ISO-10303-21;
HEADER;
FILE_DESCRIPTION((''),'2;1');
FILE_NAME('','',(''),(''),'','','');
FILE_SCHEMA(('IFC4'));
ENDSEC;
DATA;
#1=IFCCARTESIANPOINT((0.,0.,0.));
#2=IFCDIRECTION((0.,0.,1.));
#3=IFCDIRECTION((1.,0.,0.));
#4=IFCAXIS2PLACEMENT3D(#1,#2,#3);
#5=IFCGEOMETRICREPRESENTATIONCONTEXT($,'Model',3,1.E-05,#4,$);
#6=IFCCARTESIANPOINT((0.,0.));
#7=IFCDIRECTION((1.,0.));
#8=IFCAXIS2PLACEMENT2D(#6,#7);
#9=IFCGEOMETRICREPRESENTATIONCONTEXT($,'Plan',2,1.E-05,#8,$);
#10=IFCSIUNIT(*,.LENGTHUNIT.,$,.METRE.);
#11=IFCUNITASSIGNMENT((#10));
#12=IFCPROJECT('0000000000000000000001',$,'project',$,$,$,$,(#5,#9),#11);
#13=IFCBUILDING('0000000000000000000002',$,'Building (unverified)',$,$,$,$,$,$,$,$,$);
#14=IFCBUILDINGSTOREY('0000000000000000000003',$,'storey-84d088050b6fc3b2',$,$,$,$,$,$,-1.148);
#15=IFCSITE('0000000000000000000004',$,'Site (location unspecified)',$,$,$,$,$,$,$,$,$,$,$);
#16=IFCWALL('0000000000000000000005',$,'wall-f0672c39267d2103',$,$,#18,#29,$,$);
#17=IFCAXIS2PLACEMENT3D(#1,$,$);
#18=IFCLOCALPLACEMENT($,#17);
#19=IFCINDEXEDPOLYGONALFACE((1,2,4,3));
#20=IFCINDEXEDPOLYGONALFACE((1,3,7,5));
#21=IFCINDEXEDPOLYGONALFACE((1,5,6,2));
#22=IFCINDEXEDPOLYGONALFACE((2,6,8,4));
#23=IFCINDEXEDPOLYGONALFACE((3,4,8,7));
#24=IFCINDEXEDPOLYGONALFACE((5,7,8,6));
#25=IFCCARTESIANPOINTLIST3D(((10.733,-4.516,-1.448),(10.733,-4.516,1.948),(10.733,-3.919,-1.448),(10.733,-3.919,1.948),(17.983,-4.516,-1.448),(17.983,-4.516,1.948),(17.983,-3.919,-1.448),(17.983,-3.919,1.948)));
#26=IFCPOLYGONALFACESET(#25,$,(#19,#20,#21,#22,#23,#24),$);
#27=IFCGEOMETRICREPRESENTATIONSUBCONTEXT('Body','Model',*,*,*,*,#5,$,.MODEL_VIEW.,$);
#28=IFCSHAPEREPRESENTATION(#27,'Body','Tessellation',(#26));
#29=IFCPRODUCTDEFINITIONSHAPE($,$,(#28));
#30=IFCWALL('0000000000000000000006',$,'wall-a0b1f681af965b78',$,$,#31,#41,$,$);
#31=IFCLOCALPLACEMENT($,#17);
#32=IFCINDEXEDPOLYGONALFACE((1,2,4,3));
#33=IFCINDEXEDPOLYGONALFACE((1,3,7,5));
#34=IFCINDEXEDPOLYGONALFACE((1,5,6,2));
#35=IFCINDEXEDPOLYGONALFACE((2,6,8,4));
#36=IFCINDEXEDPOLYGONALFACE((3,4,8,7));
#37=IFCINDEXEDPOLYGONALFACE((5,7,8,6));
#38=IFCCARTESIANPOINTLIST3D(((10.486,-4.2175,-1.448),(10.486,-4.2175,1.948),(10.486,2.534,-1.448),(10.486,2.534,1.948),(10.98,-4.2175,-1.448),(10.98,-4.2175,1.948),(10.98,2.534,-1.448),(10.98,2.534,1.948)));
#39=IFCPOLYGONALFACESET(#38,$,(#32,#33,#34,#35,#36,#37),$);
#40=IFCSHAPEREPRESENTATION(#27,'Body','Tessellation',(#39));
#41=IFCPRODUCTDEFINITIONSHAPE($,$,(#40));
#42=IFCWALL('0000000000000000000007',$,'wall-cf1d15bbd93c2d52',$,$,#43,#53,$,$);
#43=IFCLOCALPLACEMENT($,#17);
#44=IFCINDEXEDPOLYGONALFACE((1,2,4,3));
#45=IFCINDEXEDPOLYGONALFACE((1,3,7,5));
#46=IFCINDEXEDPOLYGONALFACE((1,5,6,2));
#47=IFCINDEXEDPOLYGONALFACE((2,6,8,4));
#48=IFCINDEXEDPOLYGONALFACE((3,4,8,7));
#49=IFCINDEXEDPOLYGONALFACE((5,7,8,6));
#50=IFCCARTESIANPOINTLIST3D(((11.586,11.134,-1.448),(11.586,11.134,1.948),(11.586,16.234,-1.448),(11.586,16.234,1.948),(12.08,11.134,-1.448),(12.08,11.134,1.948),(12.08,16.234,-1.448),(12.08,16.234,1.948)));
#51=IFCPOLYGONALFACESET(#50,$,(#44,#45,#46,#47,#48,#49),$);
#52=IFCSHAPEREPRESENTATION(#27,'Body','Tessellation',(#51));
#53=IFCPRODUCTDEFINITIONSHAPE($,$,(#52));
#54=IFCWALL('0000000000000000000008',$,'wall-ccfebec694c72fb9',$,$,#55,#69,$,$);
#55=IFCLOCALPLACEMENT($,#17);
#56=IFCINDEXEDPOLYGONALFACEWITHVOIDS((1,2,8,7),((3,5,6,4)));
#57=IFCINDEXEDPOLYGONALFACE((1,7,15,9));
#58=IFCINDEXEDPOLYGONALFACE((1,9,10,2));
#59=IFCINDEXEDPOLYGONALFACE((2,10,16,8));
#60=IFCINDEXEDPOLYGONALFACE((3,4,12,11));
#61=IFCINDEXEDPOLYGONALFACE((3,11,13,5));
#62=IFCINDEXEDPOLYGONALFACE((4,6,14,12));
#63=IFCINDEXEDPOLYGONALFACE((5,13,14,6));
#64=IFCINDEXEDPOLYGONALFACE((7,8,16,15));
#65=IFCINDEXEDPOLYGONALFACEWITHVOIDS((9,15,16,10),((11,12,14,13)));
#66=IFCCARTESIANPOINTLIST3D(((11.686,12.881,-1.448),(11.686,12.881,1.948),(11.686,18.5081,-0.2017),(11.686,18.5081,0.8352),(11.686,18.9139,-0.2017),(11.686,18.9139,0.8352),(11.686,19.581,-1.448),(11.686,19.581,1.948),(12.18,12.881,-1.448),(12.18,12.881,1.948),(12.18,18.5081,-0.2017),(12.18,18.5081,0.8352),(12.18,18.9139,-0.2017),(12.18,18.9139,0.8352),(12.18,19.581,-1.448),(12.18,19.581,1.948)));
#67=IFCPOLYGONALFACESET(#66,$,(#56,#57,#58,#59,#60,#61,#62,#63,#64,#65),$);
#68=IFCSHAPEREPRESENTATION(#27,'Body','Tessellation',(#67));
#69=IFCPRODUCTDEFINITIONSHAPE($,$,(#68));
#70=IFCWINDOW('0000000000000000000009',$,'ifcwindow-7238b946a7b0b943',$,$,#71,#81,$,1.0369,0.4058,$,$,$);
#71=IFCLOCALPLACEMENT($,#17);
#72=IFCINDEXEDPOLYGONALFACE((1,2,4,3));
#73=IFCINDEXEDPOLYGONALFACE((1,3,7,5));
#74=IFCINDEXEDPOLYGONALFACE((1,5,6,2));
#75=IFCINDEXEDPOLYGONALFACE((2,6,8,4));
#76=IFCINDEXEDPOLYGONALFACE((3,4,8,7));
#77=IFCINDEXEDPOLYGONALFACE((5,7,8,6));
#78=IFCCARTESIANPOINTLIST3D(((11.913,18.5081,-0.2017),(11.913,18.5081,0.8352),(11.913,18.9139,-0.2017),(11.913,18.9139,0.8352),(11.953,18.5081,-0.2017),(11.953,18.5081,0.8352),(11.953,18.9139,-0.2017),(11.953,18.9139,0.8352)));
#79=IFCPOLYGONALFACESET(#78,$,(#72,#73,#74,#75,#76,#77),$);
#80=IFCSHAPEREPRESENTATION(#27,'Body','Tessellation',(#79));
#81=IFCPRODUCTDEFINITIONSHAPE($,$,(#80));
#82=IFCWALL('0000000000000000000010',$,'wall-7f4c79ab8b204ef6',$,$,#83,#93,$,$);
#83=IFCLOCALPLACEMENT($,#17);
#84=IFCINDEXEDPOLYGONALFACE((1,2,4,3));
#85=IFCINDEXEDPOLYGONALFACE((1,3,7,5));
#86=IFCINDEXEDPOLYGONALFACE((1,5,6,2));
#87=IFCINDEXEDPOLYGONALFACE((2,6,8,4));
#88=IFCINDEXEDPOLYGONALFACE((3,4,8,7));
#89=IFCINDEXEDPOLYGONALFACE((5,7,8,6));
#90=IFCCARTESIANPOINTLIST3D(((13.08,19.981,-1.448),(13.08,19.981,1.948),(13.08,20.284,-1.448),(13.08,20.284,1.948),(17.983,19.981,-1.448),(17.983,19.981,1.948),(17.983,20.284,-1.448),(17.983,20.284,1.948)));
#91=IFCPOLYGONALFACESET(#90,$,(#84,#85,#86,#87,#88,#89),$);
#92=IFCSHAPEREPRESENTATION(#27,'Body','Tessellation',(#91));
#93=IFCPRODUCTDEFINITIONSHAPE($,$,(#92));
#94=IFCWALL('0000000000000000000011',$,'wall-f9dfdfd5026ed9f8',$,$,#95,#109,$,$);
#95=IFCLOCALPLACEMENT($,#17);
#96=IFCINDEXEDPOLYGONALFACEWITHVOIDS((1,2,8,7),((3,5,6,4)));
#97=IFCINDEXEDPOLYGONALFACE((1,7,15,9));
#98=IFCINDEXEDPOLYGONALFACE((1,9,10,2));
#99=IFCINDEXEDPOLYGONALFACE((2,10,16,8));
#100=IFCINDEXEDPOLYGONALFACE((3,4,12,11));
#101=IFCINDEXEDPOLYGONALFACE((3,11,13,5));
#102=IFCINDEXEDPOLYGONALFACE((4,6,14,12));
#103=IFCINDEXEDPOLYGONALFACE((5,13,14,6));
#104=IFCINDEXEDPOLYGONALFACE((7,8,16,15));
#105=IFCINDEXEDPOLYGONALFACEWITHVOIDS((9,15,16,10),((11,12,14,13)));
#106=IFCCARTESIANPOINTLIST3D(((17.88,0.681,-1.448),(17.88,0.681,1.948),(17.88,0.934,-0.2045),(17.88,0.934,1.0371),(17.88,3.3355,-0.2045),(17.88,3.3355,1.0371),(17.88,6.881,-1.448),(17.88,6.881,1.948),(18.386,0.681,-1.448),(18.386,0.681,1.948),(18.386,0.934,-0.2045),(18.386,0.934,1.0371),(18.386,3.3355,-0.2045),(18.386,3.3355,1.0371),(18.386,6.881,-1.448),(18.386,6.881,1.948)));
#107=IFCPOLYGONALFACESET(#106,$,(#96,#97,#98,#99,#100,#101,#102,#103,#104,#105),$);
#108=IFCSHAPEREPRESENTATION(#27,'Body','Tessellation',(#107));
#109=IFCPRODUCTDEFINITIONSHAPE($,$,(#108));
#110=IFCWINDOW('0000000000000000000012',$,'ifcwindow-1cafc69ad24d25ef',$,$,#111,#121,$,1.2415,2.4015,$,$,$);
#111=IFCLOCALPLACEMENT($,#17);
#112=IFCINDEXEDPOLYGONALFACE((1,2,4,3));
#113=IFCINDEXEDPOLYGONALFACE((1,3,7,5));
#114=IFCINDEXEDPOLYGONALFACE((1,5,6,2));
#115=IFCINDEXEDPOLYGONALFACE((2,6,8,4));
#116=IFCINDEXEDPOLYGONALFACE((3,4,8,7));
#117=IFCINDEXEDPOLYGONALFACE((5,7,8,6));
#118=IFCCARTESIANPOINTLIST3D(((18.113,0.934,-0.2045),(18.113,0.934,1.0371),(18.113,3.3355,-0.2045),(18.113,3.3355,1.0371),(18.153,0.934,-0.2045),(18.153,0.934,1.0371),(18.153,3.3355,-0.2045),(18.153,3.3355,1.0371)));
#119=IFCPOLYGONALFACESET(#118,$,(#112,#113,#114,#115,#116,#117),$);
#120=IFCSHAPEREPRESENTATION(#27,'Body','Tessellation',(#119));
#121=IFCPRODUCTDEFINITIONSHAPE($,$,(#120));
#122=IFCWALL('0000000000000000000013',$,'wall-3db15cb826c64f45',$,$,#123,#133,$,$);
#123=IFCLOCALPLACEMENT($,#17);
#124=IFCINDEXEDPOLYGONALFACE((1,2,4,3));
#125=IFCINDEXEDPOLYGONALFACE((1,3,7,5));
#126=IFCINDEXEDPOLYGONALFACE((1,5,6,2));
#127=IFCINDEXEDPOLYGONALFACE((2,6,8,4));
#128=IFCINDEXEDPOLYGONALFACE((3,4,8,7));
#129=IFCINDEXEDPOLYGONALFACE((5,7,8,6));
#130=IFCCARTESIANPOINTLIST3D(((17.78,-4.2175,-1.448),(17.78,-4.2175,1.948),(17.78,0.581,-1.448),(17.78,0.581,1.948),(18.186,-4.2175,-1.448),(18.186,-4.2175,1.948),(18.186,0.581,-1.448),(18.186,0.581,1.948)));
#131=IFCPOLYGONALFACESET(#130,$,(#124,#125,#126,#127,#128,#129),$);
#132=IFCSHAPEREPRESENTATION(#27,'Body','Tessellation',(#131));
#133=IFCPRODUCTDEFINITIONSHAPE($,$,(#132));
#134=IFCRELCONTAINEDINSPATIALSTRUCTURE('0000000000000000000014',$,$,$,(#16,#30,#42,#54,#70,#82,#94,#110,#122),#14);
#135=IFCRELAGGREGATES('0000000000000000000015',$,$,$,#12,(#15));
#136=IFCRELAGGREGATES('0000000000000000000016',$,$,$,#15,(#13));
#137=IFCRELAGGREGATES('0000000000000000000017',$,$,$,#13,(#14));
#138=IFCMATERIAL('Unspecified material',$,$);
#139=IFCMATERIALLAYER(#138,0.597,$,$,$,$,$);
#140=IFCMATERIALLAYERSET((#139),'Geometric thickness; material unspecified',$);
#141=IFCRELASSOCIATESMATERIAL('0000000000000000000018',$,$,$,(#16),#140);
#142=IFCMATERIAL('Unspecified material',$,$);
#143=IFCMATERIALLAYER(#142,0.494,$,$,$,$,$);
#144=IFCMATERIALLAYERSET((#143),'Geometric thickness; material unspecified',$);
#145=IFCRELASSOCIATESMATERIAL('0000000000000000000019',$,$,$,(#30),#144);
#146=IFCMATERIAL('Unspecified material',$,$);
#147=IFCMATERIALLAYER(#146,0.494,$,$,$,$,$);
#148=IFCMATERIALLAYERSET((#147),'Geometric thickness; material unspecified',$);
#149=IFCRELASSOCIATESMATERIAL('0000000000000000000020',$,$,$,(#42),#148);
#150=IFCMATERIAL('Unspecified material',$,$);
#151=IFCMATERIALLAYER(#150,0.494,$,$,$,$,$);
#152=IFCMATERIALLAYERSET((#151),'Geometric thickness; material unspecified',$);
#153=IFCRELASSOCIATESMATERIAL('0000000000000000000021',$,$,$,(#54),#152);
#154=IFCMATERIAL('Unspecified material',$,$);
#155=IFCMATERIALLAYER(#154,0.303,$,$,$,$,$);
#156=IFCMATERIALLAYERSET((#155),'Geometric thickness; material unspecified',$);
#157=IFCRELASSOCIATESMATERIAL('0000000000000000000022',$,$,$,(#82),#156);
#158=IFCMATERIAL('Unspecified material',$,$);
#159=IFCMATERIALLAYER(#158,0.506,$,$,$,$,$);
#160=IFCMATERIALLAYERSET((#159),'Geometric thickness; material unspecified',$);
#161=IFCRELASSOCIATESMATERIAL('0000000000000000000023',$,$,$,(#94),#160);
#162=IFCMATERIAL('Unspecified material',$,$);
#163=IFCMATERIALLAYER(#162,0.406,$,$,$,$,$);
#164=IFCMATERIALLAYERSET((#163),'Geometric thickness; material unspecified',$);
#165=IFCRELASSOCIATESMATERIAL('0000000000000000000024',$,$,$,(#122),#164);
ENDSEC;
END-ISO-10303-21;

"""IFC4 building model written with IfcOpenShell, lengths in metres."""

from ifc_helpers import new_model, si_unit, frame, origin_with_axes, origin_2d_with_axis, place, context, subcontext, project, spatial, indexed_curve, outline, extrude, material, layer, layer_set, layer_usage, element, fill, save


model = new_model("IFC4")

# Units and contexts
model_context = context("Model", 3, precision=1e-05, world=origin_with_axes())
plan_context = context("Plan", 2, precision=1e-05, world=origin_2d_with_axis())
body_context = subcontext(model_context, "Body", "Model", "MODEL_VIEW")
ifc_project = project(units=[si_unit("LENGTHUNIT", "METRE")], contexts=[model_context, plan_context])

# Site, building, storey
site = spatial("IfcSite", under=ifc_project, Name="Site (location unspecified)")
building = spatial("IfcBuilding", under=site, Name="Building (unverified)")
storey = spatial("IfcBuildingStorey", under=building, Name="storey-84d088050b6fc3b2", Elevation=-1.148)

# Walls
ifc_material_1 = material(Name="Unspecified material")
ifc_layer_1 = layer(ifc_material_1, 0.597)
ifc_layer_set_1 = layer_set([ifc_layer_1], Name="Geometric thickness; material unspecified")
ifc_layer_usage_1 = layer_usage(ifc_layer_set_1, "AXIS2", "POSITIVE", -0.2985)
wall_1_placement = place(None, frame((17.983, -4.2175, -1.448), z_axis=(0.0, 0.0, 1.0), x_axis=(-1.0, 0.0, 0.0)))
element("IfcWall", 1, at=wall_1_placement, inside=storey, material=ifc_layer_usage_1, Name="wall-f0672c39267d2103", context=body_context, shape_type="SweptSolid", body=[
    extrude(outline(indexed_curve([(0.0, 0.0), (0.0, 0.597), (7.25, 0.597), (7.25, 0.0), (0.0, 0.0)], self_intersect=False)), frame((0.0, -0.2985, 0.0), z_axis=(0.0, 0.0, 1.0), x_axis=(1.0, 0.0, 0.0)), (0.0, 0.0, 1.0), 3.396),
])
ifc_material_2 = material(Name="Unspecified material")
ifc_layer_2 = layer(ifc_material_2, 0.494)
ifc_layer_set_2 = layer_set([ifc_layer_2], Name="Geometric thickness; material unspecified")
ifc_layer_usage_2 = layer_usage(ifc_layer_set_2, "AXIS2", "POSITIVE", -0.247)
wall_2_placement = place(None, frame((10.733, -4.2175, -1.448), z_axis=(0.0, 0.0, 1.0), x_axis=(0.0, 1.0, 0.0)))
element("IfcWall", 2, at=wall_2_placement, inside=storey, material=ifc_layer_usage_2, Name="wall-a0b1f681af965b78", context=body_context, shape_type="SweptSolid", body=[
    extrude(outline(indexed_curve([(0.0, 0.0), (0.0, 0.494), (6.7515, 0.494), (6.7515, 0.0), (0.0, 0.0)], self_intersect=False)), frame((0.0, -0.247, 0.0), z_axis=(0.0, 0.0, 1.0), x_axis=(1.0, 0.0, 0.0)), (0.0, 0.0, 1.0), 3.396),
])
ifc_material_3 = material(Name="Unspecified material")
ifc_layer_3 = layer(ifc_material_3, 0.494)
ifc_layer_set_3 = layer_set([ifc_layer_3], Name="Geometric thickness; material unspecified")
ifc_layer_usage_3 = layer_usage(ifc_layer_set_3, "AXIS2", "POSITIVE", -0.247)
wall_3_placement = place(None, frame((11.833, 11.134, -1.448), z_axis=(0.0, 0.0, 1.0), x_axis=(0.0, 1.0, 0.0)))
element("IfcWall", 3, at=wall_3_placement, inside=storey, material=ifc_layer_usage_3, Name="wall-cf1d15bbd93c2d52", context=body_context, shape_type="SweptSolid", body=[
    extrude(outline(indexed_curve([(0.0, 0.0), (0.0, 0.494), (5.1, 0.494), (5.1, 0.0), (0.0, 0.0)], self_intersect=False)), frame((0.0, -0.247, 0.0), z_axis=(0.0, 0.0, 1.0), x_axis=(1.0, 0.0, 0.0)), (0.0, 0.0, 1.0), 3.396),
])

# Wall, opening, window
ifc_material_4 = material(Name="Unspecified material")
ifc_layer_4 = layer(ifc_material_4, 0.494)
ifc_layer_set_4 = layer_set([ifc_layer_4], Name="Geometric thickness; material unspecified")
ifc_layer_usage_4 = layer_usage(ifc_layer_set_4, "AXIS2", "POSITIVE", -0.247)
wall_4_placement = place(None, frame((11.933, 12.881, -1.448), z_axis=(0.0, 0.0, 1.0), x_axis=(0.0, 1.0, 0.0)))
wall_4 = element("IfcWall", 4, at=wall_4_placement, inside=storey, material=ifc_layer_usage_4, Name="wall-ccfebec694c72fb9", context=body_context, shape_type="SweptSolid", body=[
    extrude(outline(indexed_curve([(0.0, 0.0), (0.0, 0.494), (6.7, 0.494), (6.7, 0.0), (0.0, 0.0)], self_intersect=False)), frame((0.0, -0.247, 0.0), z_axis=(0.0, 0.0, 1.0), x_axis=(1.0, 0.0, 0.0)), (0.0, 0.0, 1.0), 3.396),
])
opening_1_placement = place(wall_4_placement, frame((5.6271, -0.257, 1.2463), z_axis=(0.0, 0.0, 1.0), x_axis=(1.0, 0.0, 0.0)))
opening_1 = element("IfcOpeningElement", 5, at=opening_1_placement, cuts=wall_4, context=body_context, shape_type="SweptSolid", body=[
    extrude(outline(indexed_curve([(0.0, 0.0), (0.0, 0.514), (0.4058, 0.514), (0.4058, 0.0), (0.0, 0.0)], self_intersect=False)), origin_with_axes(), (0.0, 0.0, 1.0), 1.0369),
])
window_1_placement = place(None, frame((11.953, 18.5081, -0.2017), z_axis=(0.0, 0.0, 1.0), x_axis=(0.0, 1.0, 0.0)))
window_1 = element("IfcWindow", 6, at=window_1_placement, inside=storey, Name="ifcwindow-7238b946a7b0b943", OverallHeight=1.0369, OverallWidth=0.4058, context=body_context, shape_type="SweptSolid", body=[
    extrude(outline(indexed_curve([(0.0, 0.0), (0.0, 0.04), (0.4058, 0.04), (0.4058, 0.0), (0.0, 0.0)], self_intersect=False)), origin_with_axes(), (0.0, 0.0, 1.0), 1.0369),
])
fill(opening_1, window_1)

# Wall
ifc_material_5 = material(Name="Unspecified material")
ifc_layer_5 = layer(ifc_material_5, 0.303)
ifc_layer_set_5 = layer_set([ifc_layer_5], Name="Geometric thickness; material unspecified")
ifc_layer_usage_5 = layer_usage(ifc_layer_set_5, "AXIS2", "POSITIVE", -0.1515)
wall_5_placement = place(None, frame((13.08, 20.1325, -1.448), z_axis=(0.0, 0.0, 1.0), x_axis=(1.0, 0.0, 0.0)))
element("IfcWall", 7, at=wall_5_placement, inside=storey, material=ifc_layer_usage_5, Name="wall-7f4c79ab8b204ef6", context=body_context, shape_type="SweptSolid", body=[
    extrude(outline(indexed_curve([(0.0, 0.0), (0.0, 0.303), (4.903, 0.303), (4.903, 0.0), (0.0, 0.0)], self_intersect=False)), frame((0.0, -0.1515, 0.0), z_axis=(0.0, 0.0, 1.0), x_axis=(1.0, 0.0, 0.0)), (0.0, 0.0, 1.0), 3.396),
])

# Wall, opening, window
ifc_material_6 = material(Name="Unspecified material")
ifc_layer_6 = layer(ifc_material_6, 0.506)
ifc_layer_set_6 = layer_set([ifc_layer_6], Name="Geometric thickness; material unspecified")
ifc_layer_usage_6 = layer_usage(ifc_layer_set_6, "AXIS2", "POSITIVE", -0.253)
wall_6_placement = place(None, frame((18.133, 0.681, -1.448), z_axis=(0.0, 0.0, 1.0), x_axis=(0.0, 1.0, 0.0)))
wall_6 = element("IfcWall", 8, at=wall_6_placement, inside=storey, material=ifc_layer_usage_6, Name="wall-f9dfdfd5026ed9f8", context=body_context, shape_type="SweptSolid", body=[
    extrude(outline(indexed_curve([(0.0, 0.0), (0.0, 0.506), (6.2, 0.506), (6.2, 0.0), (0.0, 0.0)], self_intersect=False)), frame((0.0, -0.253, 0.0), z_axis=(0.0, 0.0, 1.0), x_axis=(1.0, 0.0, 0.0)), (0.0, 0.0, 1.0), 3.396),
])
opening_2_placement = place(wall_6_placement, frame((0.253, -0.263, 1.2435), z_axis=(0.0, 0.0, 1.0), x_axis=(1.0, 0.0, 0.0)))
opening_2 = element("IfcOpeningElement", 9, at=opening_2_placement, cuts=wall_6, context=body_context, shape_type="SweptSolid", body=[
    extrude(outline(indexed_curve([(0.0, 0.0), (0.0, 0.526), (2.4015, 0.526), (2.4015, 0.0), (0.0, 0.0)], self_intersect=False)), origin_with_axes(), (0.0, 0.0, 1.0), 1.2415),
])
window_2_placement = place(None, frame((18.153, 0.934, -0.2045), z_axis=(0.0, 0.0, 1.0), x_axis=(0.0, 1.0, 0.0)))
window_2 = element("IfcWindow", 10, at=window_2_placement, inside=storey, Name="ifcwindow-1cafc69ad24d25ef", OverallHeight=1.2415, OverallWidth=2.4015, context=body_context, shape_type="SweptSolid", body=[
    extrude(outline(indexed_curve([(0.0, 0.0), (0.0, 0.04), (2.4015, 0.04), (2.4015, 0.0), (0.0, 0.0)], self_intersect=False)), origin_with_axes(), (0.0, 0.0, 1.0), 1.2415),
])
fill(opening_2, window_2)

# Wall
ifc_material_7 = material(Name="Unspecified material")
ifc_layer_7 = layer(ifc_material_7, 0.406)
ifc_layer_set_7 = layer_set([ifc_layer_7], Name="Geometric thickness; material unspecified")
ifc_layer_usage_7 = layer_usage(ifc_layer_set_7, "AXIS2", "POSITIVE", -0.203)
wall_7_placement = place(None, frame((17.983, -4.2175, -1.448), z_axis=(0.0, 0.0, 1.0), x_axis=(0.0, 1.0, 0.0)))
element("IfcWall", 11, at=wall_7_placement, inside=storey, material=ifc_layer_usage_7, Name="wall-3db15cb826c64f45", context=body_context, shape_type="SweptSolid", body=[
    extrude(outline(indexed_curve([(0.0, 0.0), (0.0, 0.406), (4.7985, 0.406), (4.7985, 0.0), (0.0, 0.0)], self_intersect=False)), frame((0.0, -0.203, 0.0), z_axis=(0.0, 0.0, 1.0), x_axis=(1.0, 0.0, 0.0)), (0.0, 0.0, 1.0), 3.396),
])

save(model, "model.ifc")
